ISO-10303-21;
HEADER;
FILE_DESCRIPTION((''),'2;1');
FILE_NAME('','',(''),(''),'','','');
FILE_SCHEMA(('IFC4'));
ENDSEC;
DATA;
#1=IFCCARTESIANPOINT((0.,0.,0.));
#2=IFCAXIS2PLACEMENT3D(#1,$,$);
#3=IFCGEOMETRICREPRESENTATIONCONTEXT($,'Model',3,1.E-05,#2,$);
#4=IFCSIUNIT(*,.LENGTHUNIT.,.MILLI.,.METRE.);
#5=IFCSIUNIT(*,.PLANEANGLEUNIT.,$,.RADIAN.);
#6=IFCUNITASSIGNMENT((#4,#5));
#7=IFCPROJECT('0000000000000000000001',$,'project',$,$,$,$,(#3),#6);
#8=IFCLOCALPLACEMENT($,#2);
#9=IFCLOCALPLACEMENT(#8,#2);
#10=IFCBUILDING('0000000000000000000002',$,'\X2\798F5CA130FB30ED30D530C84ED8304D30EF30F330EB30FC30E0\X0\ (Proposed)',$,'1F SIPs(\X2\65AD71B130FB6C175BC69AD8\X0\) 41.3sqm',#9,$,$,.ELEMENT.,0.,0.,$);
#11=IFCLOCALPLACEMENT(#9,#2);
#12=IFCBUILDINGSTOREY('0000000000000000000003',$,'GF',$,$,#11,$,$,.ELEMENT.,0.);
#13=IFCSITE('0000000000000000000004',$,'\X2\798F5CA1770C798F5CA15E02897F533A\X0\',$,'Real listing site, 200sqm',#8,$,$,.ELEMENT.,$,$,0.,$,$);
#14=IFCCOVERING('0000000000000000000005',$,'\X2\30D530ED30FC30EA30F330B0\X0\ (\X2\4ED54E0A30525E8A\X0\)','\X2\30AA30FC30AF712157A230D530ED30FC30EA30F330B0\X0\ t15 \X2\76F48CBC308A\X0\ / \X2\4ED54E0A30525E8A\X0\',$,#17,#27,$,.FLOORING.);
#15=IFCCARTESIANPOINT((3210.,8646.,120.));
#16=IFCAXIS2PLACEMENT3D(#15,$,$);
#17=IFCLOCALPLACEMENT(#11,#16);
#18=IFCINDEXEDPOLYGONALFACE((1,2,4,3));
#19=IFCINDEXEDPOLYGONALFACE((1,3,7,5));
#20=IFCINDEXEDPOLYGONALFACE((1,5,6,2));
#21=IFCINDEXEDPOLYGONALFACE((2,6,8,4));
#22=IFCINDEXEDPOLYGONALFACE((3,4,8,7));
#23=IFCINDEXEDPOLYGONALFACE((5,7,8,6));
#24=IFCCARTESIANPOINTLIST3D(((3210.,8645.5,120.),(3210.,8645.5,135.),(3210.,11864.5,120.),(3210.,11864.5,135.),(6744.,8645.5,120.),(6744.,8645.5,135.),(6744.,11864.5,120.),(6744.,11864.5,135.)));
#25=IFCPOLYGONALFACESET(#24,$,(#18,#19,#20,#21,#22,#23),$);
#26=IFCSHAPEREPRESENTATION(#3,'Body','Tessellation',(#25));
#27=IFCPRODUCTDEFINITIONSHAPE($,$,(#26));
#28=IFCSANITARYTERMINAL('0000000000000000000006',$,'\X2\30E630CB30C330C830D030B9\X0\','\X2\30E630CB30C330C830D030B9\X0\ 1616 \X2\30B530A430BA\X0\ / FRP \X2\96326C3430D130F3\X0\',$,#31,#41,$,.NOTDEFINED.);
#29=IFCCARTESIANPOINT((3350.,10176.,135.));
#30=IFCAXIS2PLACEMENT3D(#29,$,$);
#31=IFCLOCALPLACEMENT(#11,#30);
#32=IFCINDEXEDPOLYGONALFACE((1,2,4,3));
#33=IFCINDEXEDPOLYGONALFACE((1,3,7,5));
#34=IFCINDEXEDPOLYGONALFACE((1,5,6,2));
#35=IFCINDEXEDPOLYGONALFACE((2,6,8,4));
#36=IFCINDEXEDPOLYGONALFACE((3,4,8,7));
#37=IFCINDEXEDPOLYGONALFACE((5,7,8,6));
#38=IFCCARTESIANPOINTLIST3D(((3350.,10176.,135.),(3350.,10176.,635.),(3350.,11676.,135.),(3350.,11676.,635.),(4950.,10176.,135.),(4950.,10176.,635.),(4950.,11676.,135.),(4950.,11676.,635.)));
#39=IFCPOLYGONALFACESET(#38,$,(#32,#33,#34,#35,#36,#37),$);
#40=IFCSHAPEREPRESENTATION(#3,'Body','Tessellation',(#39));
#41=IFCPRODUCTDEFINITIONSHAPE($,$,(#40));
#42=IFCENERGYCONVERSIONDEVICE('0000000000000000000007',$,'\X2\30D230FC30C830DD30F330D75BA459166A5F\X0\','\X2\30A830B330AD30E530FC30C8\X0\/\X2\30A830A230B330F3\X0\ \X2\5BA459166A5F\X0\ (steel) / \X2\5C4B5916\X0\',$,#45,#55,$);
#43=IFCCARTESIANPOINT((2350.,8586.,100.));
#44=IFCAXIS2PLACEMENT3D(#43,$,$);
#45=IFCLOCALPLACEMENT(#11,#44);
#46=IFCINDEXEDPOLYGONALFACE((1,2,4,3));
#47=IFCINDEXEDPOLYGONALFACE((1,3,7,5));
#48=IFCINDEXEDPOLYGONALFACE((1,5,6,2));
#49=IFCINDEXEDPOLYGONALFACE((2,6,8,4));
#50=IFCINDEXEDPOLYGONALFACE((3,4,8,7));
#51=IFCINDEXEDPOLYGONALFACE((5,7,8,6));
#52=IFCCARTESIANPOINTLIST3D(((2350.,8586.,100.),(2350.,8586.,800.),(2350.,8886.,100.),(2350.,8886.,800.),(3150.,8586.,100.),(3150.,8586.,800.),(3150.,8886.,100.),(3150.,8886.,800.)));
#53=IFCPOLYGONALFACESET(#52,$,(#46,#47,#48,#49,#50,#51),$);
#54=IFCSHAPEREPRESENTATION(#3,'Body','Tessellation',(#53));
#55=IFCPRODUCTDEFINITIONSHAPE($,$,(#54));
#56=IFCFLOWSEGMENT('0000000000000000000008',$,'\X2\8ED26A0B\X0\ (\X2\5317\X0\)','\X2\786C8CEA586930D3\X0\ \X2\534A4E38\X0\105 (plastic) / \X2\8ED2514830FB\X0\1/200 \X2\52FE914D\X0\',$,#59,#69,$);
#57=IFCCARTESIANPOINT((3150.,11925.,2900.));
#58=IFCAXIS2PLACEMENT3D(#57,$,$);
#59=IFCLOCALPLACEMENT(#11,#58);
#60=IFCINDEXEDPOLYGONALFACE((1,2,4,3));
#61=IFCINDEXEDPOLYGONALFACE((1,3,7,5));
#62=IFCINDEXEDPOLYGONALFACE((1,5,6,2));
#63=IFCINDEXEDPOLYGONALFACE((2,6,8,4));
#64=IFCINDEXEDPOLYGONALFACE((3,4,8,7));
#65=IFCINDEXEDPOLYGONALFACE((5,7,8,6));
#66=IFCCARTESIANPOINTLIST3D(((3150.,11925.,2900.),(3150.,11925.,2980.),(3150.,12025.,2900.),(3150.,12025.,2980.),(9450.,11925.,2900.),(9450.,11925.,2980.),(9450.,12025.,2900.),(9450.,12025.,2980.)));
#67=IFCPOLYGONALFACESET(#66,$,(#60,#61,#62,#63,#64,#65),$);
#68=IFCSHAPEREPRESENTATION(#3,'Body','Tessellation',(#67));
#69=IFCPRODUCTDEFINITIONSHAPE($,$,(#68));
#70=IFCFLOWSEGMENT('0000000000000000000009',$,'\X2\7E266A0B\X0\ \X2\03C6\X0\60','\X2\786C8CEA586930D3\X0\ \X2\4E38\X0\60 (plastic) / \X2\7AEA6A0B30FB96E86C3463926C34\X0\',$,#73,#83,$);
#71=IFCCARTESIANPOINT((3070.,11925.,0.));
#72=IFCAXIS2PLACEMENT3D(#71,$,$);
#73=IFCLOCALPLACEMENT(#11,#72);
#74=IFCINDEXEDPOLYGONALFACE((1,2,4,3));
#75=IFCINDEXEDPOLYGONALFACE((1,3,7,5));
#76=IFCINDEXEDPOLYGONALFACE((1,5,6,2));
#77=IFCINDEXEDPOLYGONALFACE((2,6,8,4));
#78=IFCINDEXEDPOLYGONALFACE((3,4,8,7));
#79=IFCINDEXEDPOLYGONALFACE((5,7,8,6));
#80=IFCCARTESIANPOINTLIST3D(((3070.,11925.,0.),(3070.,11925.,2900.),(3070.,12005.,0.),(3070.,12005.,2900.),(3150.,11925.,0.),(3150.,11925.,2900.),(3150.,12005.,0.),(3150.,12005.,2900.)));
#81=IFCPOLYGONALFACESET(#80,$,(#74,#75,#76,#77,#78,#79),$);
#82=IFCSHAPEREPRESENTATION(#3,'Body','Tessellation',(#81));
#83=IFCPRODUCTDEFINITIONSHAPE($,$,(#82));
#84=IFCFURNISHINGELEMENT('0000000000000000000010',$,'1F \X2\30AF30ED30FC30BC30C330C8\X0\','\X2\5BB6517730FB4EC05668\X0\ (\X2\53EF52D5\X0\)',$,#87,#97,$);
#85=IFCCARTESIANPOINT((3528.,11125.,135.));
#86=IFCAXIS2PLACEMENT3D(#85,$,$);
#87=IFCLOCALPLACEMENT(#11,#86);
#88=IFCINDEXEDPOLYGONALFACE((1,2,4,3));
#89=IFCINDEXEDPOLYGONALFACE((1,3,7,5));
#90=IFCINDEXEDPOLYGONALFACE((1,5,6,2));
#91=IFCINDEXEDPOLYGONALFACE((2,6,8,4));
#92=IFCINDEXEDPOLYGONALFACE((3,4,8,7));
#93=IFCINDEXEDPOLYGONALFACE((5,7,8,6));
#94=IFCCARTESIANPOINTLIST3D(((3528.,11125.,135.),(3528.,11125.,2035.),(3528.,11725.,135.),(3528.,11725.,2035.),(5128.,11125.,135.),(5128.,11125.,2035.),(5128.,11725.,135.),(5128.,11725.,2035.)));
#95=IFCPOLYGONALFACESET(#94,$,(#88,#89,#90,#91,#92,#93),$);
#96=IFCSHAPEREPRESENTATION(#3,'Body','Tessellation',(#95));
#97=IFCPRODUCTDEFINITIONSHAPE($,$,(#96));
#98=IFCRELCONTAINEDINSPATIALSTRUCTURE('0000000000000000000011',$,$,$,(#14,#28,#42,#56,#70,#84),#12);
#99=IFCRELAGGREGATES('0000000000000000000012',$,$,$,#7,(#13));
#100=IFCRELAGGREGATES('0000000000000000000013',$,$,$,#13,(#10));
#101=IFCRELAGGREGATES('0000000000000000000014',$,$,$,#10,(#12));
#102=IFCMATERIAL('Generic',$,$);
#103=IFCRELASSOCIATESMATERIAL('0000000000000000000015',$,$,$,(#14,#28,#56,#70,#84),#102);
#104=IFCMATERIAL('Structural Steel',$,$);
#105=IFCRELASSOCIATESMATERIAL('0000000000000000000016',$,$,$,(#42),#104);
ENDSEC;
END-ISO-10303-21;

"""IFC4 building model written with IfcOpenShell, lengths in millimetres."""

from ifc_helpers import new_model, si_unit, frame, frame_2d, origin, place, context, project, spatial, rectangle, extrude, material, element, save


model = new_model("IFC4")

# Units and contexts
model_context = context("Model", 3, precision=1e-05, world=origin())
ifc_project = project(units=[si_unit("LENGTHUNIT", "METRE", prefix="MILLI"), si_unit("PLANEANGLEUNIT", "RADIAN")], contexts=[model_context])

# Site, building, storey
site_placement = place(None, origin())
site = spatial("IfcSite", under=ifc_project, at=site_placement, Name="福岡県福岡市西区", ObjectType="Real listing site, 200sqm", CompositionType="ELEMENT", RefElevation=0.0)
building_placement = place(site_placement, origin())
building = spatial("IfcBuilding", under=site, at=building_placement, Name="福岡・ロフト付きワンルーム (Proposed)", ObjectType="1F SIPs(断熱・気密高) 41.3sqm", CompositionType="ELEMENT", ElevationOfRefHeight=0.0, ElevationOfTerrain=0.0)
storey_placement = place(building_placement, origin())
storey = spatial("IfcBuildingStorey", under=building, at=storey_placement, Name="GF", CompositionType="ELEMENT", Elevation=0.0)

# Shared definitions
ifc_material_1 = material(Name="Structural Steel")

# Covering
ifc_material_2 = material(Name="Generic")
covering_placement = place(storey_placement, frame((3210.0, 8646.0, 120.0)))
element("IfcCovering", 1, at=covering_placement, inside=storey, material=ifc_material_2, Name="フローリング (仕上げ床)", Description="オーク無垢フローリング t15 直貼り / 仕上げ床", PredefinedType="FLOORING", context=model_context, shape_type="SweptSolid", body=[
    extrude(rectangle(XDim=3534.0, YDim=3219.0, at=frame_2d((1767.0, 1609.0))), frame((3210.0, 8646.0, 120.0)), (0.0, 0.0, 1.0), 15.0),
])

# Sanitary terminal
sanitary_terminal_placement = place(storey_placement, frame((3350.0, 10176.0, 135.0)))
element("IfcSanitaryTerminal", 2, at=sanitary_terminal_placement, inside=storey, material=ifc_material_2, Name="ユニットバス", Description="ユニットバス 1616 サイズ / FRP 防水パン", PredefinedType="NOTDEFINED", context=model_context, shape_type="SweptSolid", body=[
    extrude(rectangle(XDim=1600.0, YDim=1500.0, at=frame_2d((800.0, 750.0))), frame((3350.0, 10176.0, 135.0)), (0.0, 0.0, 1.0), 500.0),
])

# Energy conversion device
energy_conversion_device_placement = place(storey_placement, frame((2350.0, 8586.0, 100.0)))
element("IfcEnergyConversionDevice", 3, at=energy_conversion_device_placement, inside=storey, material=ifc_material_1, Name="ヒートポンプ室外機", Description="エコキュート/エアコン 室外機 (steel) / 屋外", context=model_context, shape_type="SweptSolid", body=[
    extrude(rectangle(XDim=800.0, YDim=300.0, at=frame_2d((400.0, 150.0))), frame((2350.0, 8586.0, 100.0)), (0.0, 0.0, 1.0), 700.0),
])

# Flow segments
flow_segment_1_placement = place(storey_placement, frame((3150.0, 11925.0, 2900.0)))
element("IfcFlowSegment", 4, at=flow_segment_1_placement, inside=storey, material=ifc_material_2, Name="軒樋 (北)", Description="硬質塩ビ 半丸105 (plastic) / 軒先・1/200 勾配", context=model_context, shape_type="SweptSolid", body=[
    extrude(rectangle(XDim=6300.0, YDim=100.0, at=frame_2d((3150.0, 50.0))), frame((3150.0, 11925.0, 2900.0)), (0.0, 0.0, 1.0), 80.0),
])
flow_segment_2_placement = place(storey_placement, frame((3070.0, 11925.0, 0.0)))
element("IfcFlowSegment", 5, at=flow_segment_2_placement, inside=storey, material=ifc_material_2, Name="縦樋 φ60", Description="硬質塩ビ 丸60 (plastic) / 竪樋・雨水排水", context=model_context, shape_type="SweptSolid", body=[
    extrude(rectangle(XDim=80.0, YDim=80.0, at=frame_2d((40.0, 40.0))), frame((3070.0, 11925.0, 0.0)), (0.0, 0.0, 1.0), 2900.0),
])

# Furnishing element
furnishing_placement = place(storey_placement, frame((3528.0, 11125.0, 135.0)))
element("IfcFurnishingElement", 6, at=furnishing_placement, inside=storey, material=ifc_material_2, Name="1F クローゼット", Description="家具・什器 (可動)", context=model_context, shape_type="SweptSolid", body=[
    extrude(rectangle(XDim=1600.0, YDim=600.0, at=frame_2d((800.0, 300.0))), frame((3528.0, 11125.0, 135.0)), (0.0, 0.0, 1.0), 1900.0),
])

save(model, "model.ifc")
